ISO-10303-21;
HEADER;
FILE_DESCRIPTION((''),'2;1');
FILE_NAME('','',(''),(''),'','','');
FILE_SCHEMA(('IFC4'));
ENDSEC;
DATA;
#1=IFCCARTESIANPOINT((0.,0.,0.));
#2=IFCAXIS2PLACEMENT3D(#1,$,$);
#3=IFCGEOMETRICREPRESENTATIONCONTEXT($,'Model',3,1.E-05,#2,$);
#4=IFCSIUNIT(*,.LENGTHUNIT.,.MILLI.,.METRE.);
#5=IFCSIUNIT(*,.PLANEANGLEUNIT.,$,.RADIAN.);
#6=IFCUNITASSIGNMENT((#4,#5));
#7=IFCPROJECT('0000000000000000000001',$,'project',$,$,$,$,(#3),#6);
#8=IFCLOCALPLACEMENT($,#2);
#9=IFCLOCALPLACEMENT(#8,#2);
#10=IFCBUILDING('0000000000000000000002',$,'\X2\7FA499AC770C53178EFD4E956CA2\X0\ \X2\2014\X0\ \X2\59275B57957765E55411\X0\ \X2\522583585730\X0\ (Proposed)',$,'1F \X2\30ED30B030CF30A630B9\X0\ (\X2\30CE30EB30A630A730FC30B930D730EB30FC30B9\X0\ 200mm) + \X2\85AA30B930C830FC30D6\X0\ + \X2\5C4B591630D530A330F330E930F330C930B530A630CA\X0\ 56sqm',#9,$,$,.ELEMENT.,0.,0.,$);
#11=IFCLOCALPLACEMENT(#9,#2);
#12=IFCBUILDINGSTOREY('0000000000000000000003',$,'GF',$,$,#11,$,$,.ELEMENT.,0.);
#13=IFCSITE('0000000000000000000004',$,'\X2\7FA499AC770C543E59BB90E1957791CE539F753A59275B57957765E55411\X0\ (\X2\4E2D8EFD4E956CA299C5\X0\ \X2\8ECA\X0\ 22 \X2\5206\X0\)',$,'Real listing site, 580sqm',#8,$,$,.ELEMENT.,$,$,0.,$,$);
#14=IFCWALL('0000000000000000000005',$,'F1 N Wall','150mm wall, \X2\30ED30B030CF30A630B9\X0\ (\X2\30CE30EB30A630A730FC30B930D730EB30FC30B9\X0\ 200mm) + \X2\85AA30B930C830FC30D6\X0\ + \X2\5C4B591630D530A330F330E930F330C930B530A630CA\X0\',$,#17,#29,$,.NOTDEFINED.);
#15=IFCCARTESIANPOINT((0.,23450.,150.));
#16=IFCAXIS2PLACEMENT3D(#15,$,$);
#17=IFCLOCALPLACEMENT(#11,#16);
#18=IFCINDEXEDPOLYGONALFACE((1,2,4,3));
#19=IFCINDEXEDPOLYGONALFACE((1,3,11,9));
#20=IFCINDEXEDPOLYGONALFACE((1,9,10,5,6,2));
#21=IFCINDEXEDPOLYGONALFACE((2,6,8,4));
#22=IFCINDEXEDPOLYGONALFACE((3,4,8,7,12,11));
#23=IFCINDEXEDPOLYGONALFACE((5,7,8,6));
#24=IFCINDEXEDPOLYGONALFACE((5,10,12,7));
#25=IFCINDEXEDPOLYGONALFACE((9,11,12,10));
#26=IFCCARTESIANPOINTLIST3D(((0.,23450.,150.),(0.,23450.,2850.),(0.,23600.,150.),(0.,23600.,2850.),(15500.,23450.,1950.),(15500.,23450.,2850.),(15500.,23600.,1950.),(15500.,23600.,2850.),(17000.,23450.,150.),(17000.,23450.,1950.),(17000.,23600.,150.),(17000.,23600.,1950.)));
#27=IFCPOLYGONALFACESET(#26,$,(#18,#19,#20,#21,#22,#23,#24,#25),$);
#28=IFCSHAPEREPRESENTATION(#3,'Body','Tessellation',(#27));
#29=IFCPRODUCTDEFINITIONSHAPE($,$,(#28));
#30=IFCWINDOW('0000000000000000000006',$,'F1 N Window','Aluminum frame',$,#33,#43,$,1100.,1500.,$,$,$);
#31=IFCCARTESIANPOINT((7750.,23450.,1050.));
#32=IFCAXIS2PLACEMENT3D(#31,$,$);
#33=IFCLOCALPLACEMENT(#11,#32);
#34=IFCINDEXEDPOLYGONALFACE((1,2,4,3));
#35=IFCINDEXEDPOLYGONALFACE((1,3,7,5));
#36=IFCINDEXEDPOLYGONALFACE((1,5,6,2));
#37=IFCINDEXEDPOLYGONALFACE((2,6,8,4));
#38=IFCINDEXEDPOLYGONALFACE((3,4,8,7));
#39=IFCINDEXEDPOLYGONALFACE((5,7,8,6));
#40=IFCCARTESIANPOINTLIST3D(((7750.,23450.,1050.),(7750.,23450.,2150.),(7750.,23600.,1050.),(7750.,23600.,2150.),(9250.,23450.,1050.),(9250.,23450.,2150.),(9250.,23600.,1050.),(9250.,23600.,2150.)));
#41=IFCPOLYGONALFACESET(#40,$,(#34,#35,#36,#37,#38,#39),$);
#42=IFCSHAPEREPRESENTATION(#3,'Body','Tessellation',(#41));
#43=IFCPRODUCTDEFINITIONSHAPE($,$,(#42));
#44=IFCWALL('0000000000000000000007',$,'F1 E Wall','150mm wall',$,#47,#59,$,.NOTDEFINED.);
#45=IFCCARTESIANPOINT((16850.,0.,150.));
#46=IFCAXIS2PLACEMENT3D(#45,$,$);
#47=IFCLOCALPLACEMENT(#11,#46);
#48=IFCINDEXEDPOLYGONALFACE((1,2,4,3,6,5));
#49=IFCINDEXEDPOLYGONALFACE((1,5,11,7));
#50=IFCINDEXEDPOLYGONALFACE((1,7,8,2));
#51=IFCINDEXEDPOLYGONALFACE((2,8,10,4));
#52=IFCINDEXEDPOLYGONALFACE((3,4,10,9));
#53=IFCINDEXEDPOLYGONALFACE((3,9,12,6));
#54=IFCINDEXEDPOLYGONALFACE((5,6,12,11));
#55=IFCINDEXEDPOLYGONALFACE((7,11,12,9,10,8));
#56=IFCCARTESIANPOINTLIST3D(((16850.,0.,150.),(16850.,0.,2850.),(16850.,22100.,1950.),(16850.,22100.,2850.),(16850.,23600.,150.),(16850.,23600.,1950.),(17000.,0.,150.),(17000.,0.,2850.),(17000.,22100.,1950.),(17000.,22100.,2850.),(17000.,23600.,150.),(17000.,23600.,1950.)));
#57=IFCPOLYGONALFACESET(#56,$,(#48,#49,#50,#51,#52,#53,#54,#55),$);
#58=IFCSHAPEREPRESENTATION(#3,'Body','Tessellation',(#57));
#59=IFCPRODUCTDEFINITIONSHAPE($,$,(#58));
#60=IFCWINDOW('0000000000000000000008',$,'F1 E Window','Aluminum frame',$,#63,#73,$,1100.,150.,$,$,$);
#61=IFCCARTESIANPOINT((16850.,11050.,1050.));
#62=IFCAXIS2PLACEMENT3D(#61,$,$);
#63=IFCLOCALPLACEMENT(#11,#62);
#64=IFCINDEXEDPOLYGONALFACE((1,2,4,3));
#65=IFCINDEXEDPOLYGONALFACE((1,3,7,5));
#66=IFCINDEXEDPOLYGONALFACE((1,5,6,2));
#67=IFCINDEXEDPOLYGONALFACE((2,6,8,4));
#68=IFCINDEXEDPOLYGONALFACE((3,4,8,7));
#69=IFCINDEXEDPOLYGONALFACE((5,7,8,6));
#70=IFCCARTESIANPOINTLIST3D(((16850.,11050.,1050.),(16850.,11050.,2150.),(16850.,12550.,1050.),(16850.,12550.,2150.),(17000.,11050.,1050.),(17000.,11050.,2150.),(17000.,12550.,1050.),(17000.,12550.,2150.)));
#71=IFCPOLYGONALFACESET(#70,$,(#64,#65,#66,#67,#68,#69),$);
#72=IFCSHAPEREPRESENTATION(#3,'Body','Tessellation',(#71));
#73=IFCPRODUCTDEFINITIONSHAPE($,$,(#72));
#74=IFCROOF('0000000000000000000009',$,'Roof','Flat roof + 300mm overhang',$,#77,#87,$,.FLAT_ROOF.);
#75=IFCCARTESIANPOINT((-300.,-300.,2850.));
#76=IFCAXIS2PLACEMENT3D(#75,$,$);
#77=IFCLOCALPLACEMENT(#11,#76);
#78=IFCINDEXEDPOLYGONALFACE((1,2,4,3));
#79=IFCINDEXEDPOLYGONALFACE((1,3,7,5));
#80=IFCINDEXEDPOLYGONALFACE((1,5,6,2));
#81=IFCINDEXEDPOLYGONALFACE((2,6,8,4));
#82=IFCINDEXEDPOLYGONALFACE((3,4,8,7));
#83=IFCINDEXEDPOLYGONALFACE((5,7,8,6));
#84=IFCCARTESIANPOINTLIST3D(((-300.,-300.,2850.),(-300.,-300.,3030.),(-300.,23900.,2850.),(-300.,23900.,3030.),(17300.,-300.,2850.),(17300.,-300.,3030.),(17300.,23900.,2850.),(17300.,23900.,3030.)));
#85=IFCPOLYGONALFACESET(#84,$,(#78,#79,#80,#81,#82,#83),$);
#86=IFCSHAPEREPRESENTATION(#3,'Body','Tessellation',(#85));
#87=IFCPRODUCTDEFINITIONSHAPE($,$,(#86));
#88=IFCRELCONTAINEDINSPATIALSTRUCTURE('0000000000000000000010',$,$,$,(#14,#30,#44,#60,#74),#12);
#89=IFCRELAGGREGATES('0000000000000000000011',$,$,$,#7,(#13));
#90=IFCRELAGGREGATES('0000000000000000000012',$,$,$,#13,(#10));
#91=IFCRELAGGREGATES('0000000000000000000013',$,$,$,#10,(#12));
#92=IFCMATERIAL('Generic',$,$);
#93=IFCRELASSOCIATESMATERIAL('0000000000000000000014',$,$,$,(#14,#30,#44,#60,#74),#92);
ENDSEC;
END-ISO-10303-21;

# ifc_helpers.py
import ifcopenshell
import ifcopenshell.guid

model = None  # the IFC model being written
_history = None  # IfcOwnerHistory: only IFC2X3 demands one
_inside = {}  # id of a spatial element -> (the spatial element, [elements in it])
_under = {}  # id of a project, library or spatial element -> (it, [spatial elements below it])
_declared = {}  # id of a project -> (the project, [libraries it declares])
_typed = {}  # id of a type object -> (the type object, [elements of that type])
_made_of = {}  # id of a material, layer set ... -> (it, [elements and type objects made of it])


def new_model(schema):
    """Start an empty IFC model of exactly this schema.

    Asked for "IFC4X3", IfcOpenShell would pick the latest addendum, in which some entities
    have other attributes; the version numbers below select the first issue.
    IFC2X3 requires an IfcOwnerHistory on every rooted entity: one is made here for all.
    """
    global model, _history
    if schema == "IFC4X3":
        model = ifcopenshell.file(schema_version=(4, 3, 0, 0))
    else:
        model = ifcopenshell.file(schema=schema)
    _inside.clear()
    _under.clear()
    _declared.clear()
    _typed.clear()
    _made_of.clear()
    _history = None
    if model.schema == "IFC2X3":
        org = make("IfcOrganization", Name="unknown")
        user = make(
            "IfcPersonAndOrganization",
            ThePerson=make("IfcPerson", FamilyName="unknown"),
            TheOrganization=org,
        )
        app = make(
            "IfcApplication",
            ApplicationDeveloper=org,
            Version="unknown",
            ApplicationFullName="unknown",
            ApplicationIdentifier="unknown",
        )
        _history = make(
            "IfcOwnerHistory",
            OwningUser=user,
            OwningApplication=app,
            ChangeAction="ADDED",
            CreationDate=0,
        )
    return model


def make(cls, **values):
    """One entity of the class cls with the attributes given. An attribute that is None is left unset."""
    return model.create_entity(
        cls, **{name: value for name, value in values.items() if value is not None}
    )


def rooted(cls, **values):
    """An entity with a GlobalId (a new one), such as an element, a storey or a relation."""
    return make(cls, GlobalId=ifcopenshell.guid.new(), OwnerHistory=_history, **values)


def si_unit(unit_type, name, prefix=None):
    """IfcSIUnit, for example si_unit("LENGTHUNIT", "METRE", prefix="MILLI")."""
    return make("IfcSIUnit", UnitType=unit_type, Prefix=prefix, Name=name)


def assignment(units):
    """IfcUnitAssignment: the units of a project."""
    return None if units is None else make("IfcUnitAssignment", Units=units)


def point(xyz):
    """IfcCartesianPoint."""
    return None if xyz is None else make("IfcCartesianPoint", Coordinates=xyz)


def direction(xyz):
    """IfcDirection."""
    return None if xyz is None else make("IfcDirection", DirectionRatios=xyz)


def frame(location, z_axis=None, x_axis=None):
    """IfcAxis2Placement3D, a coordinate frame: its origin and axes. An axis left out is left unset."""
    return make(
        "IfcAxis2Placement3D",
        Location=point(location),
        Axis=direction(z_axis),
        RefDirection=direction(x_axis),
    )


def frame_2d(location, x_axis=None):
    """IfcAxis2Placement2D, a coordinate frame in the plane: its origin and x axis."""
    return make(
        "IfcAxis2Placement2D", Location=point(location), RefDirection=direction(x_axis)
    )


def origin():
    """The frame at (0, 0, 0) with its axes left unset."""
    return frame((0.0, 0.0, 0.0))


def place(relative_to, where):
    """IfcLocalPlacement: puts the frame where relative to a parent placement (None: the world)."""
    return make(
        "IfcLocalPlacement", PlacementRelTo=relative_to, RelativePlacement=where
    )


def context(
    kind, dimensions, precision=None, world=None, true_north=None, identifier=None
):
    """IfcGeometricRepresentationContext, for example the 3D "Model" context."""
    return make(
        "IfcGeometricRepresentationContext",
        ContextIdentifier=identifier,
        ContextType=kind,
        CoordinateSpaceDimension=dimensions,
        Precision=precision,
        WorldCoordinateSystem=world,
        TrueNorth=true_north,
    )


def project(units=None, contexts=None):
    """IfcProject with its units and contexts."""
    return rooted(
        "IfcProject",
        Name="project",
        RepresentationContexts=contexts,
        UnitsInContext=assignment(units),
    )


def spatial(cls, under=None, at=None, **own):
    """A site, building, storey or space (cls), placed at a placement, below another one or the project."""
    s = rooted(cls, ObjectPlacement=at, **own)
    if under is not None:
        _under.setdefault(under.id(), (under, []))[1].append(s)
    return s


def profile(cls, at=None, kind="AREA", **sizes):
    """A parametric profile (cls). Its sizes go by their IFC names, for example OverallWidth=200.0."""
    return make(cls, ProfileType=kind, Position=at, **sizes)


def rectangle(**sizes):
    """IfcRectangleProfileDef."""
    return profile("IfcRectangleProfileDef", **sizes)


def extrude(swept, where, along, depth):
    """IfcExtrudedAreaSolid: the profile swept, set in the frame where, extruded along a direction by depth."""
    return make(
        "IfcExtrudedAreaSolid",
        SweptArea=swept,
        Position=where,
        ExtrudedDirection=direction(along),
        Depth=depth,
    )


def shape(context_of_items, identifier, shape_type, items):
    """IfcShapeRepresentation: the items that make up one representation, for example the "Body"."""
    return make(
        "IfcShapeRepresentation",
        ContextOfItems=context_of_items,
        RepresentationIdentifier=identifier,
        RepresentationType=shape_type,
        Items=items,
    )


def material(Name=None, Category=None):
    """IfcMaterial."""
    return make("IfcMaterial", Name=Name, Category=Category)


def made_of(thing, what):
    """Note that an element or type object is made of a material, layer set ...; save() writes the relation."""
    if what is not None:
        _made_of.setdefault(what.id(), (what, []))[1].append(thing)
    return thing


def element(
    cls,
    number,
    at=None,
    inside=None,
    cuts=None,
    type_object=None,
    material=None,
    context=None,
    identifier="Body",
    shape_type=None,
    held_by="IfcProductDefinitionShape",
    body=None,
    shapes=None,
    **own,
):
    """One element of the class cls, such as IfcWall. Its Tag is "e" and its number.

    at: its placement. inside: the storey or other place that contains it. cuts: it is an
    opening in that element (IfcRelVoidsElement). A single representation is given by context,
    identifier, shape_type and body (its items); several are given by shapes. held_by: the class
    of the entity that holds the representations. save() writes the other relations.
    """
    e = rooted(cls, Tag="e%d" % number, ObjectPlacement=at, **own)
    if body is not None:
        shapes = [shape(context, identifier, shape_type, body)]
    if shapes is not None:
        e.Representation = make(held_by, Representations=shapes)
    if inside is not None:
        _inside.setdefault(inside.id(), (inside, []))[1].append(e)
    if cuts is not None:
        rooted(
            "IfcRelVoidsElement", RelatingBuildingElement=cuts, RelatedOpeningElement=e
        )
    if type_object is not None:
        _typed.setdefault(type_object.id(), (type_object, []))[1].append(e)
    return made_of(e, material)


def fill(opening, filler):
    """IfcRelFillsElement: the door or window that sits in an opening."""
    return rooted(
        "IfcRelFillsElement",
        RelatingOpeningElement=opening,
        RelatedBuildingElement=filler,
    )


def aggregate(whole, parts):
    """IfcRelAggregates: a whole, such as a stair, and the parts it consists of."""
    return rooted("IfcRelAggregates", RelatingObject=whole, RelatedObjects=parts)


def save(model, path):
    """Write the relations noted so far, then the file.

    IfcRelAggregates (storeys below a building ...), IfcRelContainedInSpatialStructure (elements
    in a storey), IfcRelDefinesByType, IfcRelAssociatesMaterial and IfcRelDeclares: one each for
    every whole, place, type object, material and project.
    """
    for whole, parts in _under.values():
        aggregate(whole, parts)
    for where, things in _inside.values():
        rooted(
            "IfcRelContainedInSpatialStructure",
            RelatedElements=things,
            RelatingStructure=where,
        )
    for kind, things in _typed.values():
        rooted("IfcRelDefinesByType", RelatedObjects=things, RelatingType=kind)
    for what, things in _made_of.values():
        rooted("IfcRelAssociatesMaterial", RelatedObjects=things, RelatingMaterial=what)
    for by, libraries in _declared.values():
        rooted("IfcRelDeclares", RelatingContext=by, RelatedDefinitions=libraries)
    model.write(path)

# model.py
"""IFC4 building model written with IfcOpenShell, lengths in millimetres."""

from ifc_helpers import new_model, si_unit, frame, frame_2d, origin, place, context, project, spatial, rectangle, extrude, material, element, fill, save


model = new_model("IFC4")

# Units and contexts
model_context = context("Model", 3, precision=1e-05, world=origin())
ifc_project = project(units=[si_unit("LENGTHUNIT", "METRE", prefix="MILLI"), si_unit("PLANEANGLEUNIT", "RADIAN")], contexts=[model_context])

# Site, building, storey
site_placement = place(None, origin())
site = spatial("IfcSite", under=ifc_project, at=site_placement, Name="群馬県吾妻郡長野原町大字長日向 (中軽井沢駅 車 22 分)", ObjectType="Real listing site, 580sqm", CompositionType="ELEMENT", RefElevation=0.0)
building_placement = place(site_placement, origin())
building = spatial("IfcBuilding", under=site, at=building_placement, Name="群馬県北軽井沢 — 大字長日向 別荘地 (Proposed)", ObjectType="1F ログハウス (ノルウェースプルース 200mm) + 薪ストーブ + 屋外フィンランドサウナ 56sqm", CompositionType="ELEMENT", ElevationOfRefHeight=0.0, ElevationOfTerrain=0.0)
storey_placement = place(building_placement, origin())
storey = spatial("IfcBuildingStorey", under=building, at=storey_placement, Name="GF", CompositionType="ELEMENT", Elevation=0.0)

# Wall, opening, window
ifc_material_1 = material(Name="Generic")
wall_1_placement = place(storey_placement, frame((0.0, 23450.0, 150.0)))
wall_1 = element("IfcWall", 1, at=wall_1_placement, inside=storey, material=ifc_material_1, Name="F1 N Wall", Description="150mm wall, ログハウス (ノルウェースプルース 200mm) + 薪ストーブ + 屋外フィンランドサウナ", PredefinedType="NOTDEFINED", context=model_context, shape_type="SweptSolid", body=[
    extrude(rectangle(XDim=17000.0, YDim=150.0, at=frame_2d((8500.0, 75.0))), frame((0.0, 23450.0, 150.0)), (0.0, 0.0, 1.0), 2700.0),
])
opening_1_placement = place(storey_placement, frame((7750.0, 23450.0, 1050.0)))
opening_1 = element("IfcOpeningElement", 2, at=opening_1_placement, cuts=wall_1, PredefinedType="NOTDEFINED", context=model_context, shape_type="SweptSolid", body=[
    extrude(rectangle(XDim=1500.0, YDim=150.0, at=frame_2d((750.0, 75.0))), frame((7750.0, 23450.0, 1050.0)), (0.0, 0.0, 1.0), 1100.0),
])
window_1_placement = place(storey_placement, frame((7750.0, 23450.0, 1050.0)))
window_1 = element("IfcWindow", 3, at=window_1_placement, inside=storey, material=ifc_material_1, Name="F1 N Window", Description="Aluminum frame", OverallHeight=1100.0, OverallWidth=1500.0, context=model_context, shape_type="SweptSolid", body=[
    extrude(rectangle(XDim=1500.0, YDim=150.0, at=frame_2d((750.0, 75.0))), frame((7750.0, 23450.0, 1050.0)), (0.0, 0.0, 1.0), 1100.0),
])
fill(opening_1, window_1)

# Wall, opening, window
wall_2_placement = place(storey_placement, frame((16850.0, 0.0, 150.0)))
wall_2 = element("IfcWall", 4, at=wall_2_placement, inside=storey, material=ifc_material_1, Name="F1 E Wall", Description="150mm wall", PredefinedType="NOTDEFINED", context=model_context, shape_type="SweptSolid", body=[
    extrude(rectangle(XDim=150.0, YDim=23600.0, at=frame_2d((75.0, 11800.0))), frame((16850.0, 0.0, 150.0)), (0.0, 0.0, 1.0), 2700.0),
])
opening_2_placement = place(storey_placement, frame((16850.0, 11050.0, 1050.0)))
opening_2 = element("IfcOpeningElement", 5, at=opening_2_placement, cuts=wall_2, PredefinedType="NOTDEFINED", context=model_context, shape_type="SweptSolid", body=[
    extrude(rectangle(XDim=150.0, YDim=1500.0, at=frame_2d((75.0, 750.0))), frame((16850.0, 11050.0, 1050.0)), (0.0, 0.0, 1.0), 1100.0),
])
window_2_placement = place(storey_placement, frame((16850.0, 11050.0, 1050.0)))
window_2 = element("IfcWindow", 6, at=window_2_placement, inside=storey, material=ifc_material_1, Name="F1 E Window", Description="Aluminum frame", OverallHeight=1100.0, OverallWidth=150.0, context=model_context, shape_type="SweptSolid", body=[
    extrude(rectangle(XDim=150.0, YDim=1500.0, at=frame_2d((75.0, 750.0))), frame((16850.0, 11050.0, 1050.0)), (0.0, 0.0, 1.0), 1100.0),
])
fill(opening_2, window_2)

# Roof
roof_placement = place(storey_placement, frame((-300.0, -300.0, 2850.0)))
element("IfcRoof", 7, at=roof_placement, inside=storey, material=ifc_material_1, Name="Roof", Description="Flat roof + 300mm overhang", PredefinedType="FLAT_ROOF", context=model_context, shape_type="SweptSolid", body=[
    extrude(rectangle(XDim=17600.0, YDim=24200.0, at=frame_2d((8800.0, 12100.0))), frame((-300.0, -300.0, 2850.0)), (0.0, 0.0, 1.0), 180.0),
])

save(model, "model.ifc")
